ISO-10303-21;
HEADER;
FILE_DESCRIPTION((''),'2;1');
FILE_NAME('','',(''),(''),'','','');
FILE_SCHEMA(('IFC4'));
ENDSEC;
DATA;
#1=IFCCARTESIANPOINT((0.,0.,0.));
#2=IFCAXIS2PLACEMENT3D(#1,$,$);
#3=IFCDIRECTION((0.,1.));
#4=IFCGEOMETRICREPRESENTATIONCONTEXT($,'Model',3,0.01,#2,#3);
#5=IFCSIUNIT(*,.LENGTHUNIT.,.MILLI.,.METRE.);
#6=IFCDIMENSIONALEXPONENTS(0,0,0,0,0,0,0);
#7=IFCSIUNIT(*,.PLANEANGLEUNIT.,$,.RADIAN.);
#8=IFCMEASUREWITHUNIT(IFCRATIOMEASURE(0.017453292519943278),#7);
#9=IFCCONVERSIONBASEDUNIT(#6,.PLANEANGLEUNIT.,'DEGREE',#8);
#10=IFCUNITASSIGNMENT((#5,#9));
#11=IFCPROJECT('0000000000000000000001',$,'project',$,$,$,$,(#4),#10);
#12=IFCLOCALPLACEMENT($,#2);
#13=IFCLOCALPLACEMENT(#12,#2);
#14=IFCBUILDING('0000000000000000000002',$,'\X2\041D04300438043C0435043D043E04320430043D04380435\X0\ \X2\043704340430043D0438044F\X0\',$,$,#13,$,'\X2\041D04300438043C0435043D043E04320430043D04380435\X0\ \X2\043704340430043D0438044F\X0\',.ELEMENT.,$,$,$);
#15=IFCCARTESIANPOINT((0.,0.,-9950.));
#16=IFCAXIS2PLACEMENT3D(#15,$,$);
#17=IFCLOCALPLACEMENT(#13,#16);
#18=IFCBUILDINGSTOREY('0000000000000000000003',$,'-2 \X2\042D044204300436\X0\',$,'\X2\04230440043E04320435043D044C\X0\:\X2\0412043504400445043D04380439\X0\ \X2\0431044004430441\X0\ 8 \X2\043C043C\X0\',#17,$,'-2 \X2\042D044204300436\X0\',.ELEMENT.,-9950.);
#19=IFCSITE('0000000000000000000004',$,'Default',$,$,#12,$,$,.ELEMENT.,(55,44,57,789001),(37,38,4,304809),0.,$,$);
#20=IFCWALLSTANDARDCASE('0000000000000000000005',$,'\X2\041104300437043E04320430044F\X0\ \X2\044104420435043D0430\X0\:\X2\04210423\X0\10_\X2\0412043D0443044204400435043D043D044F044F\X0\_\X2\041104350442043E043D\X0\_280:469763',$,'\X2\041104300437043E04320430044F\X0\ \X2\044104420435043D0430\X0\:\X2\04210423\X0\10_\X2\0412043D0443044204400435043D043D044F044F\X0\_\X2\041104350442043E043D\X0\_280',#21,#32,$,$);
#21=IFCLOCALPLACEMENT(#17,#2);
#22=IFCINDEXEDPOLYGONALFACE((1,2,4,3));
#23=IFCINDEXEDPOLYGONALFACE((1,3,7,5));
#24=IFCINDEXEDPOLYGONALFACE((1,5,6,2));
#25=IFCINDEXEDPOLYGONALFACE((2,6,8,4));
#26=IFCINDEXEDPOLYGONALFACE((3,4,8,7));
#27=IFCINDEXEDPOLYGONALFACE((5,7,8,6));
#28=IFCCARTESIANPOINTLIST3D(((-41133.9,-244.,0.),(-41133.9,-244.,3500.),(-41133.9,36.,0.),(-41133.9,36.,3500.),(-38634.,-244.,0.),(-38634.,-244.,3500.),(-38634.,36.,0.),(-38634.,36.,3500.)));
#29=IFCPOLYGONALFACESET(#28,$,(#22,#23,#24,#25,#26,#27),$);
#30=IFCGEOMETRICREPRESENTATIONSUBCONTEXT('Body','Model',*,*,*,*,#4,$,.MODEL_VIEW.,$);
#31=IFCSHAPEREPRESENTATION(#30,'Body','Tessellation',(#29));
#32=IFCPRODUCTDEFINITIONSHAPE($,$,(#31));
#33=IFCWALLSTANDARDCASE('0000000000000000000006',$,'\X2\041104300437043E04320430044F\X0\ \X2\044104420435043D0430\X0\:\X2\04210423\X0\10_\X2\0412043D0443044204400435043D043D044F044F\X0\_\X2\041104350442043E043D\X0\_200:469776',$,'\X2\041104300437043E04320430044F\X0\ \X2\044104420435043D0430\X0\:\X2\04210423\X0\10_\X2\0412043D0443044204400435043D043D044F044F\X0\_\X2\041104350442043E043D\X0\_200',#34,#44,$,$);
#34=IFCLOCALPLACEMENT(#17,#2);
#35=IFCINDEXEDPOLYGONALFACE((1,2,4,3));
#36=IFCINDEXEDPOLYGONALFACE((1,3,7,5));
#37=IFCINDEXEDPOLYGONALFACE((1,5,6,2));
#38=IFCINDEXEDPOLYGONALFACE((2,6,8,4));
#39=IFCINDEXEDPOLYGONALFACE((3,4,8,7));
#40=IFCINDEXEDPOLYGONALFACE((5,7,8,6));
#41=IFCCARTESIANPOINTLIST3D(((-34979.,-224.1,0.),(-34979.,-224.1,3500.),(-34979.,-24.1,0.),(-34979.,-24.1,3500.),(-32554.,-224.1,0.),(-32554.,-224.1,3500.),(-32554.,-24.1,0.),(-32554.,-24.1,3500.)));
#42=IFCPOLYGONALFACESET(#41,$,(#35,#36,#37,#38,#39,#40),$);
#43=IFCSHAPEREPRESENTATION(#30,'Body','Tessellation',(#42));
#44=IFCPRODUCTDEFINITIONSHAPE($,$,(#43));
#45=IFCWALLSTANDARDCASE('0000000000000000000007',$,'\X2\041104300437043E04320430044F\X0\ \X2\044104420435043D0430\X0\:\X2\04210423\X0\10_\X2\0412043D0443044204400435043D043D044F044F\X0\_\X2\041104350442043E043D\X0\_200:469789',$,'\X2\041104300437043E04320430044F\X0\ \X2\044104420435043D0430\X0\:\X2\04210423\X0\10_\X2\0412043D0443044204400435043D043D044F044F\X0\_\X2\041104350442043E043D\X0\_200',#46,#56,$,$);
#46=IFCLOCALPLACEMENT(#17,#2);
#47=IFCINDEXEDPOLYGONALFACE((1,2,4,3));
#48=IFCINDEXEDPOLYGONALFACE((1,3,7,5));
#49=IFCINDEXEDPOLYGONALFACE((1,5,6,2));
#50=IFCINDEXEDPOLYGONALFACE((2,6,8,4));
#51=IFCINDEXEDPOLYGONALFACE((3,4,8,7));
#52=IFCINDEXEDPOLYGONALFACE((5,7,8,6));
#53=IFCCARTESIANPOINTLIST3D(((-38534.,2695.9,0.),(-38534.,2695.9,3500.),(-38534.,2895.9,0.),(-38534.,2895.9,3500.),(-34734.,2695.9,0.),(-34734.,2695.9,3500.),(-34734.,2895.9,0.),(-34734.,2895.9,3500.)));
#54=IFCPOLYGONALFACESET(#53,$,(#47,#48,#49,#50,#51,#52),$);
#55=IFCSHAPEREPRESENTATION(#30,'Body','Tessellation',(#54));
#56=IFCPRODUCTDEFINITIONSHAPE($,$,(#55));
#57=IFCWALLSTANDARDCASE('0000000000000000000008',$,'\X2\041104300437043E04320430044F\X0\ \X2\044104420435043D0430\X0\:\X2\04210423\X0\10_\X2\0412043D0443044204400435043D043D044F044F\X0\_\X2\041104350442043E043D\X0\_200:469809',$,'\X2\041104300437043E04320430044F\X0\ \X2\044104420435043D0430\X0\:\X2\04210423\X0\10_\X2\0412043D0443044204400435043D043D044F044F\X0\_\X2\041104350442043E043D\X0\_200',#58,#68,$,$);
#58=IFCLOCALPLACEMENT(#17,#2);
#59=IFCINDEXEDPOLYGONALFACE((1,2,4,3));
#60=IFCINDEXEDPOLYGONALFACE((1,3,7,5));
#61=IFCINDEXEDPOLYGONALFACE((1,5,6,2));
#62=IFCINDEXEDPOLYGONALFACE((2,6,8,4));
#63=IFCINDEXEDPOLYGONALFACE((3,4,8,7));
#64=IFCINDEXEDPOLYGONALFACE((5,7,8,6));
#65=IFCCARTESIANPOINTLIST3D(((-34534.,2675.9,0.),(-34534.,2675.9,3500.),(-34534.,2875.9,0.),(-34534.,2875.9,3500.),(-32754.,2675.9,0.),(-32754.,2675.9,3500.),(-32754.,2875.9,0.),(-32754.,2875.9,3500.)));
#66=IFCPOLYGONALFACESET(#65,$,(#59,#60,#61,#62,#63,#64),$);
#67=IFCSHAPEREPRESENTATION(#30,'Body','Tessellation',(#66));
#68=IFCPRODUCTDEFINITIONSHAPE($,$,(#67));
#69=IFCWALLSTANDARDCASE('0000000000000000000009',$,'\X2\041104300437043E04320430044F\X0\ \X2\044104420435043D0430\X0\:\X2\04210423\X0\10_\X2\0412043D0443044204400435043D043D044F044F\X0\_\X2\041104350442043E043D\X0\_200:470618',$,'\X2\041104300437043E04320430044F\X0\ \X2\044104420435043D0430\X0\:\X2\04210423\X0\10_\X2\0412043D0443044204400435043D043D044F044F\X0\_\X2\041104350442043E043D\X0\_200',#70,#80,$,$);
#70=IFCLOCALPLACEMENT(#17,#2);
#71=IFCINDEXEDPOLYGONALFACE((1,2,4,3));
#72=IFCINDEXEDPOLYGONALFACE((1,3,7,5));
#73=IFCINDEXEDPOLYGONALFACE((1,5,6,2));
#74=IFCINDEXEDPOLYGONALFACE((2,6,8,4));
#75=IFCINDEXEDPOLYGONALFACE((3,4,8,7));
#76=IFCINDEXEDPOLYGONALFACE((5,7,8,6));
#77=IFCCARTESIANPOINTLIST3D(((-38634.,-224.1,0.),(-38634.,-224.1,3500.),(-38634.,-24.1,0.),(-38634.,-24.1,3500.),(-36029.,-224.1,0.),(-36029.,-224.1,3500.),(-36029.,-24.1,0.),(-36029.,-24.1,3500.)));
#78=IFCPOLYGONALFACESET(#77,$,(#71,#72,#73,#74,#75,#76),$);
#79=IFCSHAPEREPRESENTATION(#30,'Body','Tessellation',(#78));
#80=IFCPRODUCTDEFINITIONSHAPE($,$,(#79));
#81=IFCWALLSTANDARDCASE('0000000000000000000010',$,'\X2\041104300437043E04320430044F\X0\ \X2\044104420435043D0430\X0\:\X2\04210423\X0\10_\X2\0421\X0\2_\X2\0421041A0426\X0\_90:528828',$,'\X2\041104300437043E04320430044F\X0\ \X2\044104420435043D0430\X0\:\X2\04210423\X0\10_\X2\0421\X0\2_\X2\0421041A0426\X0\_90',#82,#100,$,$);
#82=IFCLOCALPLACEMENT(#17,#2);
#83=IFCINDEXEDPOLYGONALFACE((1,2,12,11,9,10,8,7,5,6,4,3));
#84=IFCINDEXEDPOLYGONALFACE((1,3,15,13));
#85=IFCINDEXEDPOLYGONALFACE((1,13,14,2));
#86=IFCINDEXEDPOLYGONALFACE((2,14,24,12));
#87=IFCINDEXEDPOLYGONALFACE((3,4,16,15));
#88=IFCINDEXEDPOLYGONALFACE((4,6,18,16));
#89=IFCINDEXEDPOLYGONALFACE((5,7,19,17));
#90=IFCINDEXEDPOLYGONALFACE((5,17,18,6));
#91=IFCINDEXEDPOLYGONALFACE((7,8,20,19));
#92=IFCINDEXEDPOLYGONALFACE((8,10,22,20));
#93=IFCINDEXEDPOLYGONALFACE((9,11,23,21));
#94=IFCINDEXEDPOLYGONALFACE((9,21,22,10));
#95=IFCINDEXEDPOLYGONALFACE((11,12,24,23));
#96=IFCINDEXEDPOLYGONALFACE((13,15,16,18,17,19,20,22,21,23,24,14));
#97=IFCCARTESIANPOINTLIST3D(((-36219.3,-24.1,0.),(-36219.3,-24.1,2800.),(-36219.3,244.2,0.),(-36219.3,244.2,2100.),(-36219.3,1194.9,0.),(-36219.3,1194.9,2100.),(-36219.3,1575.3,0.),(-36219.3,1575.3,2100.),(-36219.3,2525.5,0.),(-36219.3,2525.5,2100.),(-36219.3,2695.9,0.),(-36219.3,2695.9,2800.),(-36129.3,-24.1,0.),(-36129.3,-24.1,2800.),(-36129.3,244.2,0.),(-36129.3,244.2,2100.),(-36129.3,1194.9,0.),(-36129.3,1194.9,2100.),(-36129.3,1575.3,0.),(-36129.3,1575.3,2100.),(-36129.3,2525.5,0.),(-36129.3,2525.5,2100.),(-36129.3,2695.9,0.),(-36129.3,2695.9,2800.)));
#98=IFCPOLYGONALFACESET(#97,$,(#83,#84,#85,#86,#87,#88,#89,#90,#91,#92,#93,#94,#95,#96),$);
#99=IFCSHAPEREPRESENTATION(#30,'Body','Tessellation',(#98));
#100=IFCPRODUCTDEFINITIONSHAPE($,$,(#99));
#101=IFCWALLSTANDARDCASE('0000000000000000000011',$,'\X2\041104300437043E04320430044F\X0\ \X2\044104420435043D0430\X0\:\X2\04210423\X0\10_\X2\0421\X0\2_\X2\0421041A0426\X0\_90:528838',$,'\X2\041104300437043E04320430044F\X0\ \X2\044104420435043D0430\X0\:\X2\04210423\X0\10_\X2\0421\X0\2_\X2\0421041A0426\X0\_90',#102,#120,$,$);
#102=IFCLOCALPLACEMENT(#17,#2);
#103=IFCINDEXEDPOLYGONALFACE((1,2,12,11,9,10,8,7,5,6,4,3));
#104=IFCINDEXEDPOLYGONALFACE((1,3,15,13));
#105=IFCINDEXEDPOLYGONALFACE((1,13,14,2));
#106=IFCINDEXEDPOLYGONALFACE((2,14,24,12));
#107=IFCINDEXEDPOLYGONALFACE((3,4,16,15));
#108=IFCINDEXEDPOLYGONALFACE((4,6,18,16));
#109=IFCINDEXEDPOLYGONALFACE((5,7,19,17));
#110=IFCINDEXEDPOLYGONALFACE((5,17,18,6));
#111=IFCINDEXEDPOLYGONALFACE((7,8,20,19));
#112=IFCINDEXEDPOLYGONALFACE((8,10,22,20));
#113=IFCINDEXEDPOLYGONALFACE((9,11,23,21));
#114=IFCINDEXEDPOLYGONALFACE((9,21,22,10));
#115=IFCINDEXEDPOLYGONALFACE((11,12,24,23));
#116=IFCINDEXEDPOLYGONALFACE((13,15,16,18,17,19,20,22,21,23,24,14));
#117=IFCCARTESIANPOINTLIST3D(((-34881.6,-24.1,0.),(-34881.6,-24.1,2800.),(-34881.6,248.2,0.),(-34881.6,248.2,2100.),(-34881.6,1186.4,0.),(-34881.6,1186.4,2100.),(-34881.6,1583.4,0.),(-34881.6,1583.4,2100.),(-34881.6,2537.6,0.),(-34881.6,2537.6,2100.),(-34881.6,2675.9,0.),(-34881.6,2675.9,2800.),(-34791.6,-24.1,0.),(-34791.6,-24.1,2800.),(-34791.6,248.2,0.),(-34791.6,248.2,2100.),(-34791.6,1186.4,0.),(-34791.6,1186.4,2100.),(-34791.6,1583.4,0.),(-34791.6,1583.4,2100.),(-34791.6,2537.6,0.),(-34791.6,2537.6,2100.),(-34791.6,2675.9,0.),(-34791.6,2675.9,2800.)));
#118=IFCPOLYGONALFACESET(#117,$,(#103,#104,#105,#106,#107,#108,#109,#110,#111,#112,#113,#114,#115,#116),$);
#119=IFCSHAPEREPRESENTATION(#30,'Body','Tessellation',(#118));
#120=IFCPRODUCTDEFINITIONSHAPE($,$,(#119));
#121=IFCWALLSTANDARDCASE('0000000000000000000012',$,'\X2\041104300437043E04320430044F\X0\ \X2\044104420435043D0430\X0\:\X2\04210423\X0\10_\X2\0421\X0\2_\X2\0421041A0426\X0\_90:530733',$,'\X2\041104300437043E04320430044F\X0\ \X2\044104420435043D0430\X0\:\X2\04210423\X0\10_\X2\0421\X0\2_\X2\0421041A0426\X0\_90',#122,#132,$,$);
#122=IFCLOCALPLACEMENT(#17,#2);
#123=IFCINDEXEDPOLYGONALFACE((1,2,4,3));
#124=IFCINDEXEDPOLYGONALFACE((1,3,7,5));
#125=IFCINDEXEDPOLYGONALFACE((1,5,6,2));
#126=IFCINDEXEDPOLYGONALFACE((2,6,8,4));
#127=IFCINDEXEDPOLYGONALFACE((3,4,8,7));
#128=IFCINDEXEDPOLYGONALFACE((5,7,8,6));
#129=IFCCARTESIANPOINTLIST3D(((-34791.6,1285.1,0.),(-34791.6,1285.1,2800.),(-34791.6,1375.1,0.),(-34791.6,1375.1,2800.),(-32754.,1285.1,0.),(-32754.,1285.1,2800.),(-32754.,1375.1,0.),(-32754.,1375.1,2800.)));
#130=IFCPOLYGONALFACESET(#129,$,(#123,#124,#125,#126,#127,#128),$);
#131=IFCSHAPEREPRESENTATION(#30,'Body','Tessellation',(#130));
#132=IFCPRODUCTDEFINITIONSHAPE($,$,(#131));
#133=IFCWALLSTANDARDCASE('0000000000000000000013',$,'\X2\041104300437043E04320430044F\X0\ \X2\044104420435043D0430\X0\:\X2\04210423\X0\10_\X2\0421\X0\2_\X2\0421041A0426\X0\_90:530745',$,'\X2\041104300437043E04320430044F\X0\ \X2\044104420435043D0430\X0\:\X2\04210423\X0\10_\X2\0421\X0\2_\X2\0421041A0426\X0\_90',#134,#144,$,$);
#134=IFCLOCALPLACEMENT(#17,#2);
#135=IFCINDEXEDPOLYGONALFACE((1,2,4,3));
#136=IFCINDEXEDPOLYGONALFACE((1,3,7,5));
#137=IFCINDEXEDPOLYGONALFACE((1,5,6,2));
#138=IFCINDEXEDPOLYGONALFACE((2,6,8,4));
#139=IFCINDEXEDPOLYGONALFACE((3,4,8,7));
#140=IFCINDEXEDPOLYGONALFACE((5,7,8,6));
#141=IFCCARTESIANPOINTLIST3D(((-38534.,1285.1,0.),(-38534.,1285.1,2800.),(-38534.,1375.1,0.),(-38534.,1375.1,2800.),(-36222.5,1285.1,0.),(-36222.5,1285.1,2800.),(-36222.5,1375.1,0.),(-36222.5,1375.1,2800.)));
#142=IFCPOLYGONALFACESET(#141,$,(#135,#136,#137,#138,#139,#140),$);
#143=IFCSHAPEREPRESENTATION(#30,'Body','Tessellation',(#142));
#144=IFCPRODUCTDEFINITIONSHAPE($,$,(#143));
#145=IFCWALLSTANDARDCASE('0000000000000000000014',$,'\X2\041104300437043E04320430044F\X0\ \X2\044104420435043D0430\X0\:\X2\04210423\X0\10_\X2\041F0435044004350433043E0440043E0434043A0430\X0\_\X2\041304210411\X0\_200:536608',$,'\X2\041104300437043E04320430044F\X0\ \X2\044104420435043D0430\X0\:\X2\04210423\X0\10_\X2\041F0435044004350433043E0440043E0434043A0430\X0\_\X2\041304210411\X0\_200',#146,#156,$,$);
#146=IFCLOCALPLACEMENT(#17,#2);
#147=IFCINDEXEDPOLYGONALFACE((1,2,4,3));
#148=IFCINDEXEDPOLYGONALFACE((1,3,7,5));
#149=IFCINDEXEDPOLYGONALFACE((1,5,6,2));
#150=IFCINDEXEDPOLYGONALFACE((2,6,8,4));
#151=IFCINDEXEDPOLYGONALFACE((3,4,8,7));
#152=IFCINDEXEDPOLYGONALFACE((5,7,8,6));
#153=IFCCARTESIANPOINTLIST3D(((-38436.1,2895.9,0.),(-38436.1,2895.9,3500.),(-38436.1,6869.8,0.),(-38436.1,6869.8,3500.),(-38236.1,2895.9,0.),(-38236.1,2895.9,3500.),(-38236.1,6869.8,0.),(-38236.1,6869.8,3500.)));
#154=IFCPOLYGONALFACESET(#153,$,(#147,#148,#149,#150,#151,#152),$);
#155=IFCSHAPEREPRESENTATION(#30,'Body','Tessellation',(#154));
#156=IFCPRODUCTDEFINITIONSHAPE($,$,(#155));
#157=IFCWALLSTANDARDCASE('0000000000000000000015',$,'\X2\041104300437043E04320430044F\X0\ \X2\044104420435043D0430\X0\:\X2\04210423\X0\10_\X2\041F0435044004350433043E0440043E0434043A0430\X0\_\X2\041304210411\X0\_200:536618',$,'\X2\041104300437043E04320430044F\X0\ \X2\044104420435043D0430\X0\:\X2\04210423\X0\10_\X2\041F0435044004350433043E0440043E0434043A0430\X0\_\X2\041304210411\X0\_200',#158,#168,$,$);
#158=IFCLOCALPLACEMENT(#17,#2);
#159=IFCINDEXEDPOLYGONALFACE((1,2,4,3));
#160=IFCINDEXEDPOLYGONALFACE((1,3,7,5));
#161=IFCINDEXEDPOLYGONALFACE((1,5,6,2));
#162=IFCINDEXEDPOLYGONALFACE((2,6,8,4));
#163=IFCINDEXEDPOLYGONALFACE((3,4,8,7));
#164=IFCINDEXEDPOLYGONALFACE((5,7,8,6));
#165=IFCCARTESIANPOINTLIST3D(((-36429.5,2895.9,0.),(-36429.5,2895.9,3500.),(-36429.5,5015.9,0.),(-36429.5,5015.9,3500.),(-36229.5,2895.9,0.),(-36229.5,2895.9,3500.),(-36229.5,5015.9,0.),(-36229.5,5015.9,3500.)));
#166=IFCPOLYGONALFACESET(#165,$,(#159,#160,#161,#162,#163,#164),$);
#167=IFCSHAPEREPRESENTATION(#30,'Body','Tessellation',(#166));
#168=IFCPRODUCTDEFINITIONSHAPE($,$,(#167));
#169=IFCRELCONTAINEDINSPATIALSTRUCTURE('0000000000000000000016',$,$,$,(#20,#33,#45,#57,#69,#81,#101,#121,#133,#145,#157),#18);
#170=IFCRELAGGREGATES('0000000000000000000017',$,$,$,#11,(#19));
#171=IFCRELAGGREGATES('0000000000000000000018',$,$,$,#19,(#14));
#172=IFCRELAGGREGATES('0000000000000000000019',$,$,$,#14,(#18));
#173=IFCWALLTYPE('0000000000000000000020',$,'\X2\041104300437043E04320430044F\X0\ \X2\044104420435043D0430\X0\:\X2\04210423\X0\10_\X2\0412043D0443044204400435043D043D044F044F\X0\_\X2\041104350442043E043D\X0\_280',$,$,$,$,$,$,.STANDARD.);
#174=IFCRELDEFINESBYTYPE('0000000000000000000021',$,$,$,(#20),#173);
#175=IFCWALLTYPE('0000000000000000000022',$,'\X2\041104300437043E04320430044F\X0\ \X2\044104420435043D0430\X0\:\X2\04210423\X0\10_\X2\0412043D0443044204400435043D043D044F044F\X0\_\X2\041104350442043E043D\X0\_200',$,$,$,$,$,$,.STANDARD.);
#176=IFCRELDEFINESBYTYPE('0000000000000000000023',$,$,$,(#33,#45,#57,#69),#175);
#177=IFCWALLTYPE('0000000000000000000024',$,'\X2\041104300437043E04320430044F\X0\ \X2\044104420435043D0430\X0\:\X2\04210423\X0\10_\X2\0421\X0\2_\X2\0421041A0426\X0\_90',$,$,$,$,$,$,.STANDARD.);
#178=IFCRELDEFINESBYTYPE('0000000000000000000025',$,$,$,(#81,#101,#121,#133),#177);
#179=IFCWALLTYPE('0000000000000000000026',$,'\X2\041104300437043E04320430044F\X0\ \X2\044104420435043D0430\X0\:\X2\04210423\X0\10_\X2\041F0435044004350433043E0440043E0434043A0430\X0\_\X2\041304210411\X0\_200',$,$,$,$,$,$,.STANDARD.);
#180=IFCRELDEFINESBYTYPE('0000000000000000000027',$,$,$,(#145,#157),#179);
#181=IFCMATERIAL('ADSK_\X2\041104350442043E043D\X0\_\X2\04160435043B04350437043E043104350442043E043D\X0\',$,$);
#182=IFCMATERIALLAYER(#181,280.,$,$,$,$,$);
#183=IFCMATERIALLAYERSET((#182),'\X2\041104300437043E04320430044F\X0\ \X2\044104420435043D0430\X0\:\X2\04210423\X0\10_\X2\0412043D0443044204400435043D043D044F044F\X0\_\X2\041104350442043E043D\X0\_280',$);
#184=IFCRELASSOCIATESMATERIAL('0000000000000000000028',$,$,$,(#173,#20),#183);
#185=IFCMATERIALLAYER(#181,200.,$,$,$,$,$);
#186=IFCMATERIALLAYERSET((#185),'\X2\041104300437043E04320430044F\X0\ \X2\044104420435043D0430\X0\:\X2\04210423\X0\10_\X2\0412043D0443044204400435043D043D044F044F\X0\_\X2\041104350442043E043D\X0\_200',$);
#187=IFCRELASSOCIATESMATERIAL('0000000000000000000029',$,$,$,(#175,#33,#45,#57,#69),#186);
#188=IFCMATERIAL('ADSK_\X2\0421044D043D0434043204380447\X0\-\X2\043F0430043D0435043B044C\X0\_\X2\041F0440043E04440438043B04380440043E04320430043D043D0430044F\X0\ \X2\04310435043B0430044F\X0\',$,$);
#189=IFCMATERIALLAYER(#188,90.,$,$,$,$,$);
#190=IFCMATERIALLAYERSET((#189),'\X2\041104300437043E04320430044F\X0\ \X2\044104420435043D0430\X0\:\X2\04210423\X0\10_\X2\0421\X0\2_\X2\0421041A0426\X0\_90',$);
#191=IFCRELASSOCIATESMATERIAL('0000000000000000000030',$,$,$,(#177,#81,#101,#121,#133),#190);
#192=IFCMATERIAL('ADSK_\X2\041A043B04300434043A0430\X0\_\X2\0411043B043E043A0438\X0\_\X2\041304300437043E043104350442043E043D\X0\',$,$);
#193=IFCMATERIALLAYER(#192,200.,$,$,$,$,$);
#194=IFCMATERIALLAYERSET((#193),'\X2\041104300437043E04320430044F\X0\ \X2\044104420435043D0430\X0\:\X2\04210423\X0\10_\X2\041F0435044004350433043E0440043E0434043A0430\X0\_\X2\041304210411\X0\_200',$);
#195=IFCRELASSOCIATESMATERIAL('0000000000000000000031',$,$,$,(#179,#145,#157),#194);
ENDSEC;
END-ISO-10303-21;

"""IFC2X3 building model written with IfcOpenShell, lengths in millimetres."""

from ifc_helpers import new_model, entity, si_unit, converted_unit, direction, frame, frame_2d, origin, place, context, subcontext, project, spatial, rectangle, extrude, material, layer, layer_set, layer_usage, type_object, element, save


model = new_model("IFC2X3")

# Units and contexts
model_context = context("Model", 3, precision=0.01, world=origin(), true_north=direction((0.0, 1.0)))
body_context = subcontext(model_context, "Body", "Model", "MODEL_VIEW")
ifc_project = project(units=[si_unit("LENGTHUNIT", "METRE", prefix="MILLI"), converted_unit("PLANEANGLEUNIT", "DEGREE", entity("IfcRatioMeasure", 0.017453292519943278), si_unit("PLANEANGLEUNIT", "RADIAN"), dimensions=[0, 0, 0, 0, 0, 0, 0])], contexts=[model_context])

# Site, building, storey
site_placement = place(None, origin())
site = spatial("IfcSite", under=ifc_project, at=site_placement, Name="Default", CompositionType="ELEMENT", RefLatitude=(55, 44, 57, 789001), RefLongitude=(37, 38, 4, 304809), RefElevation=0.0)
building_placement = place(site_placement, origin())
building = spatial("IfcBuilding", under=site, at=building_placement, Name="Наименование здания", LongName="Наименование здания", CompositionType="ELEMENT")
storey_placement = place(building_placement, frame((0.0, 0.0, -9950.0)))
storey = spatial("IfcBuildingStorey", under=building, at=storey_placement, Name="-2 Этаж", ObjectType="Уровень:Верхний брус 8 мм", LongName="-2 Этаж", CompositionType="ELEMENT", Elevation=-9950.0)

# Shared definitions
ifc_material_1 = material(Name="ADSK_Бетон_Железобетон")

# Walls
ifc_layer_1 = layer(ifc_material_1, 280.0)
ifc_layer_set_1 = layer_set([ifc_layer_1], Name="Базовая стена:СУ10_Внутренняя_Бетон_280")
ifc_layer_usage_1 = layer_usage(ifc_layer_set_1, "AXIS2", "NEGATIVE", 140.0)
wall_type_1 = type_object("IfcWallType", Name="Базовая стена:СУ10_Внутренняя_Бетон_280", PredefinedType="STANDARD", material=ifc_layer_set_1)
wall_1_placement = place(storey_placement, frame((-38634.0, -104.0, 0.0), z_axis=(0.0, 0.0, 1.0), x_axis=(-1.0, 0.0, 0.0)))
element("IfcWallStandardCase", 1, at=wall_1_placement, inside=storey, type_object=wall_type_1, material=ifc_layer_usage_1, Name="Базовая стена:СУ10_Внутренняя_Бетон_280:469763", ObjectType="Базовая стена:СУ10_Внутренняя_Бетон_280", context=body_context, shape_type="SweptSolid", body=[
    extrude(rectangle(XDim=2500.0, YDim=280.0, at=frame_2d((1250.0, 0.0), x_axis=(-1.0, 0.0))), origin(), (0.0, 0.0, 1.0), 3500.0),
])
ifc_layer_2 = layer(ifc_material_1, 200.0)
ifc_layer_set_2 = layer_set([ifc_layer_2], Name="Базовая стена:СУ10_Внутренняя_Бетон_200")
ifc_layer_usage_2 = layer_usage(ifc_layer_set_2, "AXIS2", "NEGATIVE", 100.0)
wall_type_2 = type_object("IfcWallType", Name="Базовая стена:СУ10_Внутренняя_Бетон_200", PredefinedType="STANDARD", material=ifc_layer_set_2)
wall_2_placement = place(storey_placement, frame((-32554.0, -124.1, 0.0), z_axis=(0.0, 0.0, 1.0), x_axis=(-1.0, 0.0, 0.0)))
element("IfcWallStandardCase", 2, at=wall_2_placement, inside=storey, type_object=wall_type_2, material=ifc_layer_usage_2, Name="Базовая стена:СУ10_Внутренняя_Бетон_200:469776", ObjectType="Базовая стена:СУ10_Внутренняя_Бетон_200", context=body_context, shape_type="SweptSolid", body=[
    extrude(rectangle(XDim=2425.0, YDim=200.0, at=frame_2d((1212.5, 0.0), x_axis=(-1.0, 0.0))), origin(), (0.0, 0.0, 1.0), 3500.0),
])
wall_3_placement = place(storey_placement, frame((-34734.0, 2795.9, 0.0), z_axis=(0.0, 0.0, 1.0), x_axis=(-1.0, 0.0, 0.0)))
element("IfcWallStandardCase", 3, at=wall_3_placement, inside=storey, type_object=wall_type_2, material=ifc_layer_usage_2, Name="Базовая стена:СУ10_Внутренняя_Бетон_200:469789", ObjectType="Базовая стена:СУ10_Внутренняя_Бетон_200", context=body_context, shape_type="SweptSolid", body=[
    extrude(rectangle(XDim=3800.0, YDim=200.0, at=frame_2d((1900.0, 0.0), x_axis=(-1.0, 0.0))), origin(), (0.0, 0.0, 1.0), 3500.0),
])
wall_4_placement = place(storey_placement, frame((-32754.0, 2775.9, 0.0), z_axis=(0.0, 0.0, 1.0), x_axis=(-1.0, 0.0, 0.0)))
element("IfcWallStandardCase", 4, at=wall_4_placement, inside=storey, type_object=wall_type_2, material=ifc_layer_usage_2, Name="Базовая стена:СУ10_Внутренняя_Бетон_200:469809", ObjectType="Базовая стена:СУ10_Внутренняя_Бетон_200", context=body_context, shape_type="SweptSolid", body=[
    extrude(rectangle(XDim=1780.0, YDim=200.0, at=frame_2d((890.0, 0.0), x_axis=(-1.0, 0.0))), origin(), (0.0, 0.0, 1.0), 3500.0),
])
wall_5_placement = place(storey_placement, frame((-36029.0, -124.1, 0.0), z_axis=(0.0, 0.0, 1.0), x_axis=(-1.0, 0.0, 0.0)))
element("IfcWallStandardCase", 5, at=wall_5_placement, inside=storey, type_object=wall_type_2, material=ifc_layer_usage_2, Name="Базовая стена:СУ10_Внутренняя_Бетон_200:470618", ObjectType="Базовая стена:СУ10_Внутренняя_Бетон_200", context=body_context, shape_type="SweptSolid", body=[
    extrude(rectangle(XDim=2605.0, YDim=200.0, at=frame_2d((1302.5, 0.0), x_axis=(-1.0, 0.0))), origin(), (0.0, 0.0, 1.0), 3500.0),
])

# Walls, openings
ifc_material_2 = material(Name="ADSK_Сэндвич-панель_Профилированная белая")
ifc_layer_3 = layer(ifc_material_2, 90.0)
ifc_layer_set_3 = layer_set([ifc_layer_3], Name="Базовая стена:СУ10_С2_СКЦ_90")
ifc_layer_usage_3 = layer_usage(ifc_layer_set_3, "AXIS2", "NEGATIVE", 45.0)
wall_type_3 = type_object("IfcWallType", Name="Базовая стена:СУ10_С2_СКЦ_90", PredefinedType="STANDARD", material=ifc_layer_set_3)
wall_6_placement = place(storey_placement, frame((-36174.3, 2695.9, 0.0), z_axis=(0.0, 0.0, 1.0), x_axis=(0.0, -1.0, 0.0)))
wall_6 = element("IfcWallStandardCase", 6, at=wall_6_placement, inside=storey, type_object=wall_type_3, material=ifc_layer_usage_3, Name="Базовая стена:СУ10_С2_СКЦ_90:528828", ObjectType="Базовая стена:СУ10_С2_СКЦ_90", context=body_context, shape_type="SweptSolid", body=[
    extrude(rectangle(XDim=2720.1, YDim=90.0, at=frame_2d((1360.0, 0.0), x_axis=(1.0, 0.0))), origin(), (0.0, 0.0, 1.0), 2800.0),
])
opening_1_placement = place(wall_6_placement, origin())
element("IfcOpeningElement", 7, at=opening_1_placement, cuts=wall_6, ObjectType="Opening", context=body_context, shape_type="SweptSolid", body=[
    extrude(rectangle(XDim=2100.0, YDim=950.2, at=frame_2d((0.0, 0.0), x_axis=(1.0, 0.0))), frame((645.5, -45.0, 1050.0), z_axis=(0.0, 1.0, 0.0), x_axis=(0.0, 0.0, -1.0)), (0.0, 0.0, 1.0), 90.0),
])
opening_2_placement = place(wall_6_placement, origin())
element("IfcOpeningElement", 8, at=opening_2_placement, cuts=wall_6, ObjectType="Opening", context=body_context, shape_type="SweptSolid", body=[
    extrude(rectangle(XDim=2100.0, YDim=950.7, at=frame_2d((0.0, 0.0), x_axis=(1.0, 0.0))), frame((1976.4, -45.0, 1050.0), z_axis=(0.0, 1.0, 0.0), x_axis=(0.0, 0.0, -1.0)), (0.0, 0.0, 1.0), 90.0),
])
wall_7_placement = place(storey_placement, frame((-34836.6, 2675.9, 0.0), z_axis=(0.0, 0.0, 1.0), x_axis=(0.0, -1.0, 0.0)))
wall_7 = element("IfcWallStandardCase", 9, at=wall_7_placement, inside=storey, type_object=wall_type_3, material=ifc_layer_usage_3, Name="Базовая стена:СУ10_С2_СКЦ_90:528838", ObjectType="Базовая стена:СУ10_С2_СКЦ_90", context=body_context, shape_type="SweptSolid", body=[
    extrude(rectangle(XDim=2700.1, YDim=90.0, at=frame_2d((1350.0, 0.0), x_axis=(1.0, 0.0))), origin(), (0.0, 0.0, 1.0), 2800.0),
])
opening_3_placement = place(wall_7_placement, origin())
element("IfcOpeningElement", 10, at=opening_3_placement, cuts=wall_7, ObjectType="Opening", context=body_context, shape_type="SweptSolid", body=[
    extrude(rectangle(XDim=2100.0, YDim=954.2, at=frame_2d((0.0, 0.0), x_axis=(1.0, 0.0))), frame((615.4, -45.0, 1050.0), z_axis=(0.0, 1.0, 0.0), x_axis=(0.0, 0.0, -1.0)), (0.0, 0.0, 1.0), 90.0),
])
opening_4_placement = place(wall_7_placement, origin())
element("IfcOpeningElement", 11, at=opening_4_placement, cuts=wall_7, ObjectType="Opening", context=body_context, shape_type="SweptSolid", body=[
    extrude(rectangle(XDim=2100.0, YDim=938.3, at=frame_2d((0.0, 0.0), x_axis=(1.0, 0.0))), frame((1958.6, -45.0, 1050.0), z_axis=(0.0, 1.0, 0.0), x_axis=(0.0, 0.0, -1.0)), (0.0, 0.0, 1.0), 90.0),
])

# Walls
wall_8_placement = place(storey_placement, frame((-32754.0, 1330.1, 0.0), z_axis=(0.0, 0.0, 1.0), x_axis=(-1.0, 0.0, 0.0)))
element("IfcWallStandardCase", 12, at=wall_8_placement, inside=storey, type_object=wall_type_3, material=ifc_layer_usage_3, Name="Базовая стена:СУ10_С2_СКЦ_90:530733", ObjectType="Базовая стена:СУ10_С2_СКЦ_90", context=body_context, shape_type="SweptSolid", body=[
    extrude(rectangle(XDim=2037.6, YDim=90.0, at=frame_2d((1018.8, 0.0), x_axis=(-1.0, 0.0))), origin(), (0.0, 0.0, 1.0), 2800.0),
])
wall_9_placement = place(storey_placement, frame((-36222.5, 1330.1, 0.0), z_axis=(0.0, 0.0, 1.0), x_axis=(-1.0, 0.0, 0.0)))
element("IfcWallStandardCase", 13, at=wall_9_placement, inside=storey, type_object=wall_type_3, material=ifc_layer_usage_3, Name="Базовая стена:СУ10_С2_СКЦ_90:530745", ObjectType="Базовая стена:СУ10_С2_СКЦ_90", context=body_context, shape_type="SweptSolid", body=[
    extrude(rectangle(XDim=2311.5, YDim=90.0, at=frame_2d((1155.8, 0.0), x_axis=(-1.0, 0.0))), origin(), (0.0, 0.0, 1.0), 2800.0),
])
ifc_material_3 = material(Name="ADSK_Кладка_Блоки_Газобетон")
ifc_layer_4 = layer(ifc_material_3, 200.0)
ifc_layer_set_4 = layer_set([ifc_layer_4], Name="Базовая стена:СУ10_Перегородка_ГСБ_200")
ifc_layer_usage_4 = layer_usage(ifc_layer_set_4, "AXIS2", "NEGATIVE", 100.0)
wall_type_4 = type_object("IfcWallType", Name="Базовая стена:СУ10_Перегородка_ГСБ_200", PredefinedType="STANDARD", material=ifc_layer_set_4)
wall_10_placement = place(storey_placement, frame((-38336.1, 2895.9, 0.0), z_axis=(0.0, 0.0, 1.0), x_axis=(0.0, 1.0, 0.0)))
element("IfcWallStandardCase", 14, at=wall_10_placement, inside=storey, type_object=wall_type_4, material=ifc_layer_usage_4, Name="Базовая стена:СУ10_Перегородка_ГСБ_200:536608", ObjectType="Базовая стена:СУ10_Перегородка_ГСБ_200", context=body_context, shape_type="SweptSolid", body=[
    extrude(rectangle(XDim=3973.9, YDim=200.0, at=frame_2d((1986.9, 0.0), x_axis=(-1.0, 0.0))), origin(), (0.0, 0.0, 1.0), 3500.0),
])
wall_11_placement = place(storey_placement, frame((-36329.5, 2895.9, 0.0), z_axis=(0.0, 0.0, 1.0), x_axis=(0.0, 1.0, 0.0)))
element("IfcWallStandardCase", 15, at=wall_11_placement, inside=storey, type_object=wall_type_4, material=ifc_layer_usage_4, Name="Базовая стена:СУ10_Перегородка_ГСБ_200:536618", ObjectType="Базовая стена:СУ10_Перегородка_ГСБ_200", context=body_context, shape_type="SweptSolid", body=[
    extrude(rectangle(XDim=2120.0, YDim=200.0, at=frame_2d((1060.0, 0.0), x_axis=(-1.0, 0.0))), origin(), (0.0, 0.0, 1.0), 3500.0),
])

save(model, "model.ifc")
